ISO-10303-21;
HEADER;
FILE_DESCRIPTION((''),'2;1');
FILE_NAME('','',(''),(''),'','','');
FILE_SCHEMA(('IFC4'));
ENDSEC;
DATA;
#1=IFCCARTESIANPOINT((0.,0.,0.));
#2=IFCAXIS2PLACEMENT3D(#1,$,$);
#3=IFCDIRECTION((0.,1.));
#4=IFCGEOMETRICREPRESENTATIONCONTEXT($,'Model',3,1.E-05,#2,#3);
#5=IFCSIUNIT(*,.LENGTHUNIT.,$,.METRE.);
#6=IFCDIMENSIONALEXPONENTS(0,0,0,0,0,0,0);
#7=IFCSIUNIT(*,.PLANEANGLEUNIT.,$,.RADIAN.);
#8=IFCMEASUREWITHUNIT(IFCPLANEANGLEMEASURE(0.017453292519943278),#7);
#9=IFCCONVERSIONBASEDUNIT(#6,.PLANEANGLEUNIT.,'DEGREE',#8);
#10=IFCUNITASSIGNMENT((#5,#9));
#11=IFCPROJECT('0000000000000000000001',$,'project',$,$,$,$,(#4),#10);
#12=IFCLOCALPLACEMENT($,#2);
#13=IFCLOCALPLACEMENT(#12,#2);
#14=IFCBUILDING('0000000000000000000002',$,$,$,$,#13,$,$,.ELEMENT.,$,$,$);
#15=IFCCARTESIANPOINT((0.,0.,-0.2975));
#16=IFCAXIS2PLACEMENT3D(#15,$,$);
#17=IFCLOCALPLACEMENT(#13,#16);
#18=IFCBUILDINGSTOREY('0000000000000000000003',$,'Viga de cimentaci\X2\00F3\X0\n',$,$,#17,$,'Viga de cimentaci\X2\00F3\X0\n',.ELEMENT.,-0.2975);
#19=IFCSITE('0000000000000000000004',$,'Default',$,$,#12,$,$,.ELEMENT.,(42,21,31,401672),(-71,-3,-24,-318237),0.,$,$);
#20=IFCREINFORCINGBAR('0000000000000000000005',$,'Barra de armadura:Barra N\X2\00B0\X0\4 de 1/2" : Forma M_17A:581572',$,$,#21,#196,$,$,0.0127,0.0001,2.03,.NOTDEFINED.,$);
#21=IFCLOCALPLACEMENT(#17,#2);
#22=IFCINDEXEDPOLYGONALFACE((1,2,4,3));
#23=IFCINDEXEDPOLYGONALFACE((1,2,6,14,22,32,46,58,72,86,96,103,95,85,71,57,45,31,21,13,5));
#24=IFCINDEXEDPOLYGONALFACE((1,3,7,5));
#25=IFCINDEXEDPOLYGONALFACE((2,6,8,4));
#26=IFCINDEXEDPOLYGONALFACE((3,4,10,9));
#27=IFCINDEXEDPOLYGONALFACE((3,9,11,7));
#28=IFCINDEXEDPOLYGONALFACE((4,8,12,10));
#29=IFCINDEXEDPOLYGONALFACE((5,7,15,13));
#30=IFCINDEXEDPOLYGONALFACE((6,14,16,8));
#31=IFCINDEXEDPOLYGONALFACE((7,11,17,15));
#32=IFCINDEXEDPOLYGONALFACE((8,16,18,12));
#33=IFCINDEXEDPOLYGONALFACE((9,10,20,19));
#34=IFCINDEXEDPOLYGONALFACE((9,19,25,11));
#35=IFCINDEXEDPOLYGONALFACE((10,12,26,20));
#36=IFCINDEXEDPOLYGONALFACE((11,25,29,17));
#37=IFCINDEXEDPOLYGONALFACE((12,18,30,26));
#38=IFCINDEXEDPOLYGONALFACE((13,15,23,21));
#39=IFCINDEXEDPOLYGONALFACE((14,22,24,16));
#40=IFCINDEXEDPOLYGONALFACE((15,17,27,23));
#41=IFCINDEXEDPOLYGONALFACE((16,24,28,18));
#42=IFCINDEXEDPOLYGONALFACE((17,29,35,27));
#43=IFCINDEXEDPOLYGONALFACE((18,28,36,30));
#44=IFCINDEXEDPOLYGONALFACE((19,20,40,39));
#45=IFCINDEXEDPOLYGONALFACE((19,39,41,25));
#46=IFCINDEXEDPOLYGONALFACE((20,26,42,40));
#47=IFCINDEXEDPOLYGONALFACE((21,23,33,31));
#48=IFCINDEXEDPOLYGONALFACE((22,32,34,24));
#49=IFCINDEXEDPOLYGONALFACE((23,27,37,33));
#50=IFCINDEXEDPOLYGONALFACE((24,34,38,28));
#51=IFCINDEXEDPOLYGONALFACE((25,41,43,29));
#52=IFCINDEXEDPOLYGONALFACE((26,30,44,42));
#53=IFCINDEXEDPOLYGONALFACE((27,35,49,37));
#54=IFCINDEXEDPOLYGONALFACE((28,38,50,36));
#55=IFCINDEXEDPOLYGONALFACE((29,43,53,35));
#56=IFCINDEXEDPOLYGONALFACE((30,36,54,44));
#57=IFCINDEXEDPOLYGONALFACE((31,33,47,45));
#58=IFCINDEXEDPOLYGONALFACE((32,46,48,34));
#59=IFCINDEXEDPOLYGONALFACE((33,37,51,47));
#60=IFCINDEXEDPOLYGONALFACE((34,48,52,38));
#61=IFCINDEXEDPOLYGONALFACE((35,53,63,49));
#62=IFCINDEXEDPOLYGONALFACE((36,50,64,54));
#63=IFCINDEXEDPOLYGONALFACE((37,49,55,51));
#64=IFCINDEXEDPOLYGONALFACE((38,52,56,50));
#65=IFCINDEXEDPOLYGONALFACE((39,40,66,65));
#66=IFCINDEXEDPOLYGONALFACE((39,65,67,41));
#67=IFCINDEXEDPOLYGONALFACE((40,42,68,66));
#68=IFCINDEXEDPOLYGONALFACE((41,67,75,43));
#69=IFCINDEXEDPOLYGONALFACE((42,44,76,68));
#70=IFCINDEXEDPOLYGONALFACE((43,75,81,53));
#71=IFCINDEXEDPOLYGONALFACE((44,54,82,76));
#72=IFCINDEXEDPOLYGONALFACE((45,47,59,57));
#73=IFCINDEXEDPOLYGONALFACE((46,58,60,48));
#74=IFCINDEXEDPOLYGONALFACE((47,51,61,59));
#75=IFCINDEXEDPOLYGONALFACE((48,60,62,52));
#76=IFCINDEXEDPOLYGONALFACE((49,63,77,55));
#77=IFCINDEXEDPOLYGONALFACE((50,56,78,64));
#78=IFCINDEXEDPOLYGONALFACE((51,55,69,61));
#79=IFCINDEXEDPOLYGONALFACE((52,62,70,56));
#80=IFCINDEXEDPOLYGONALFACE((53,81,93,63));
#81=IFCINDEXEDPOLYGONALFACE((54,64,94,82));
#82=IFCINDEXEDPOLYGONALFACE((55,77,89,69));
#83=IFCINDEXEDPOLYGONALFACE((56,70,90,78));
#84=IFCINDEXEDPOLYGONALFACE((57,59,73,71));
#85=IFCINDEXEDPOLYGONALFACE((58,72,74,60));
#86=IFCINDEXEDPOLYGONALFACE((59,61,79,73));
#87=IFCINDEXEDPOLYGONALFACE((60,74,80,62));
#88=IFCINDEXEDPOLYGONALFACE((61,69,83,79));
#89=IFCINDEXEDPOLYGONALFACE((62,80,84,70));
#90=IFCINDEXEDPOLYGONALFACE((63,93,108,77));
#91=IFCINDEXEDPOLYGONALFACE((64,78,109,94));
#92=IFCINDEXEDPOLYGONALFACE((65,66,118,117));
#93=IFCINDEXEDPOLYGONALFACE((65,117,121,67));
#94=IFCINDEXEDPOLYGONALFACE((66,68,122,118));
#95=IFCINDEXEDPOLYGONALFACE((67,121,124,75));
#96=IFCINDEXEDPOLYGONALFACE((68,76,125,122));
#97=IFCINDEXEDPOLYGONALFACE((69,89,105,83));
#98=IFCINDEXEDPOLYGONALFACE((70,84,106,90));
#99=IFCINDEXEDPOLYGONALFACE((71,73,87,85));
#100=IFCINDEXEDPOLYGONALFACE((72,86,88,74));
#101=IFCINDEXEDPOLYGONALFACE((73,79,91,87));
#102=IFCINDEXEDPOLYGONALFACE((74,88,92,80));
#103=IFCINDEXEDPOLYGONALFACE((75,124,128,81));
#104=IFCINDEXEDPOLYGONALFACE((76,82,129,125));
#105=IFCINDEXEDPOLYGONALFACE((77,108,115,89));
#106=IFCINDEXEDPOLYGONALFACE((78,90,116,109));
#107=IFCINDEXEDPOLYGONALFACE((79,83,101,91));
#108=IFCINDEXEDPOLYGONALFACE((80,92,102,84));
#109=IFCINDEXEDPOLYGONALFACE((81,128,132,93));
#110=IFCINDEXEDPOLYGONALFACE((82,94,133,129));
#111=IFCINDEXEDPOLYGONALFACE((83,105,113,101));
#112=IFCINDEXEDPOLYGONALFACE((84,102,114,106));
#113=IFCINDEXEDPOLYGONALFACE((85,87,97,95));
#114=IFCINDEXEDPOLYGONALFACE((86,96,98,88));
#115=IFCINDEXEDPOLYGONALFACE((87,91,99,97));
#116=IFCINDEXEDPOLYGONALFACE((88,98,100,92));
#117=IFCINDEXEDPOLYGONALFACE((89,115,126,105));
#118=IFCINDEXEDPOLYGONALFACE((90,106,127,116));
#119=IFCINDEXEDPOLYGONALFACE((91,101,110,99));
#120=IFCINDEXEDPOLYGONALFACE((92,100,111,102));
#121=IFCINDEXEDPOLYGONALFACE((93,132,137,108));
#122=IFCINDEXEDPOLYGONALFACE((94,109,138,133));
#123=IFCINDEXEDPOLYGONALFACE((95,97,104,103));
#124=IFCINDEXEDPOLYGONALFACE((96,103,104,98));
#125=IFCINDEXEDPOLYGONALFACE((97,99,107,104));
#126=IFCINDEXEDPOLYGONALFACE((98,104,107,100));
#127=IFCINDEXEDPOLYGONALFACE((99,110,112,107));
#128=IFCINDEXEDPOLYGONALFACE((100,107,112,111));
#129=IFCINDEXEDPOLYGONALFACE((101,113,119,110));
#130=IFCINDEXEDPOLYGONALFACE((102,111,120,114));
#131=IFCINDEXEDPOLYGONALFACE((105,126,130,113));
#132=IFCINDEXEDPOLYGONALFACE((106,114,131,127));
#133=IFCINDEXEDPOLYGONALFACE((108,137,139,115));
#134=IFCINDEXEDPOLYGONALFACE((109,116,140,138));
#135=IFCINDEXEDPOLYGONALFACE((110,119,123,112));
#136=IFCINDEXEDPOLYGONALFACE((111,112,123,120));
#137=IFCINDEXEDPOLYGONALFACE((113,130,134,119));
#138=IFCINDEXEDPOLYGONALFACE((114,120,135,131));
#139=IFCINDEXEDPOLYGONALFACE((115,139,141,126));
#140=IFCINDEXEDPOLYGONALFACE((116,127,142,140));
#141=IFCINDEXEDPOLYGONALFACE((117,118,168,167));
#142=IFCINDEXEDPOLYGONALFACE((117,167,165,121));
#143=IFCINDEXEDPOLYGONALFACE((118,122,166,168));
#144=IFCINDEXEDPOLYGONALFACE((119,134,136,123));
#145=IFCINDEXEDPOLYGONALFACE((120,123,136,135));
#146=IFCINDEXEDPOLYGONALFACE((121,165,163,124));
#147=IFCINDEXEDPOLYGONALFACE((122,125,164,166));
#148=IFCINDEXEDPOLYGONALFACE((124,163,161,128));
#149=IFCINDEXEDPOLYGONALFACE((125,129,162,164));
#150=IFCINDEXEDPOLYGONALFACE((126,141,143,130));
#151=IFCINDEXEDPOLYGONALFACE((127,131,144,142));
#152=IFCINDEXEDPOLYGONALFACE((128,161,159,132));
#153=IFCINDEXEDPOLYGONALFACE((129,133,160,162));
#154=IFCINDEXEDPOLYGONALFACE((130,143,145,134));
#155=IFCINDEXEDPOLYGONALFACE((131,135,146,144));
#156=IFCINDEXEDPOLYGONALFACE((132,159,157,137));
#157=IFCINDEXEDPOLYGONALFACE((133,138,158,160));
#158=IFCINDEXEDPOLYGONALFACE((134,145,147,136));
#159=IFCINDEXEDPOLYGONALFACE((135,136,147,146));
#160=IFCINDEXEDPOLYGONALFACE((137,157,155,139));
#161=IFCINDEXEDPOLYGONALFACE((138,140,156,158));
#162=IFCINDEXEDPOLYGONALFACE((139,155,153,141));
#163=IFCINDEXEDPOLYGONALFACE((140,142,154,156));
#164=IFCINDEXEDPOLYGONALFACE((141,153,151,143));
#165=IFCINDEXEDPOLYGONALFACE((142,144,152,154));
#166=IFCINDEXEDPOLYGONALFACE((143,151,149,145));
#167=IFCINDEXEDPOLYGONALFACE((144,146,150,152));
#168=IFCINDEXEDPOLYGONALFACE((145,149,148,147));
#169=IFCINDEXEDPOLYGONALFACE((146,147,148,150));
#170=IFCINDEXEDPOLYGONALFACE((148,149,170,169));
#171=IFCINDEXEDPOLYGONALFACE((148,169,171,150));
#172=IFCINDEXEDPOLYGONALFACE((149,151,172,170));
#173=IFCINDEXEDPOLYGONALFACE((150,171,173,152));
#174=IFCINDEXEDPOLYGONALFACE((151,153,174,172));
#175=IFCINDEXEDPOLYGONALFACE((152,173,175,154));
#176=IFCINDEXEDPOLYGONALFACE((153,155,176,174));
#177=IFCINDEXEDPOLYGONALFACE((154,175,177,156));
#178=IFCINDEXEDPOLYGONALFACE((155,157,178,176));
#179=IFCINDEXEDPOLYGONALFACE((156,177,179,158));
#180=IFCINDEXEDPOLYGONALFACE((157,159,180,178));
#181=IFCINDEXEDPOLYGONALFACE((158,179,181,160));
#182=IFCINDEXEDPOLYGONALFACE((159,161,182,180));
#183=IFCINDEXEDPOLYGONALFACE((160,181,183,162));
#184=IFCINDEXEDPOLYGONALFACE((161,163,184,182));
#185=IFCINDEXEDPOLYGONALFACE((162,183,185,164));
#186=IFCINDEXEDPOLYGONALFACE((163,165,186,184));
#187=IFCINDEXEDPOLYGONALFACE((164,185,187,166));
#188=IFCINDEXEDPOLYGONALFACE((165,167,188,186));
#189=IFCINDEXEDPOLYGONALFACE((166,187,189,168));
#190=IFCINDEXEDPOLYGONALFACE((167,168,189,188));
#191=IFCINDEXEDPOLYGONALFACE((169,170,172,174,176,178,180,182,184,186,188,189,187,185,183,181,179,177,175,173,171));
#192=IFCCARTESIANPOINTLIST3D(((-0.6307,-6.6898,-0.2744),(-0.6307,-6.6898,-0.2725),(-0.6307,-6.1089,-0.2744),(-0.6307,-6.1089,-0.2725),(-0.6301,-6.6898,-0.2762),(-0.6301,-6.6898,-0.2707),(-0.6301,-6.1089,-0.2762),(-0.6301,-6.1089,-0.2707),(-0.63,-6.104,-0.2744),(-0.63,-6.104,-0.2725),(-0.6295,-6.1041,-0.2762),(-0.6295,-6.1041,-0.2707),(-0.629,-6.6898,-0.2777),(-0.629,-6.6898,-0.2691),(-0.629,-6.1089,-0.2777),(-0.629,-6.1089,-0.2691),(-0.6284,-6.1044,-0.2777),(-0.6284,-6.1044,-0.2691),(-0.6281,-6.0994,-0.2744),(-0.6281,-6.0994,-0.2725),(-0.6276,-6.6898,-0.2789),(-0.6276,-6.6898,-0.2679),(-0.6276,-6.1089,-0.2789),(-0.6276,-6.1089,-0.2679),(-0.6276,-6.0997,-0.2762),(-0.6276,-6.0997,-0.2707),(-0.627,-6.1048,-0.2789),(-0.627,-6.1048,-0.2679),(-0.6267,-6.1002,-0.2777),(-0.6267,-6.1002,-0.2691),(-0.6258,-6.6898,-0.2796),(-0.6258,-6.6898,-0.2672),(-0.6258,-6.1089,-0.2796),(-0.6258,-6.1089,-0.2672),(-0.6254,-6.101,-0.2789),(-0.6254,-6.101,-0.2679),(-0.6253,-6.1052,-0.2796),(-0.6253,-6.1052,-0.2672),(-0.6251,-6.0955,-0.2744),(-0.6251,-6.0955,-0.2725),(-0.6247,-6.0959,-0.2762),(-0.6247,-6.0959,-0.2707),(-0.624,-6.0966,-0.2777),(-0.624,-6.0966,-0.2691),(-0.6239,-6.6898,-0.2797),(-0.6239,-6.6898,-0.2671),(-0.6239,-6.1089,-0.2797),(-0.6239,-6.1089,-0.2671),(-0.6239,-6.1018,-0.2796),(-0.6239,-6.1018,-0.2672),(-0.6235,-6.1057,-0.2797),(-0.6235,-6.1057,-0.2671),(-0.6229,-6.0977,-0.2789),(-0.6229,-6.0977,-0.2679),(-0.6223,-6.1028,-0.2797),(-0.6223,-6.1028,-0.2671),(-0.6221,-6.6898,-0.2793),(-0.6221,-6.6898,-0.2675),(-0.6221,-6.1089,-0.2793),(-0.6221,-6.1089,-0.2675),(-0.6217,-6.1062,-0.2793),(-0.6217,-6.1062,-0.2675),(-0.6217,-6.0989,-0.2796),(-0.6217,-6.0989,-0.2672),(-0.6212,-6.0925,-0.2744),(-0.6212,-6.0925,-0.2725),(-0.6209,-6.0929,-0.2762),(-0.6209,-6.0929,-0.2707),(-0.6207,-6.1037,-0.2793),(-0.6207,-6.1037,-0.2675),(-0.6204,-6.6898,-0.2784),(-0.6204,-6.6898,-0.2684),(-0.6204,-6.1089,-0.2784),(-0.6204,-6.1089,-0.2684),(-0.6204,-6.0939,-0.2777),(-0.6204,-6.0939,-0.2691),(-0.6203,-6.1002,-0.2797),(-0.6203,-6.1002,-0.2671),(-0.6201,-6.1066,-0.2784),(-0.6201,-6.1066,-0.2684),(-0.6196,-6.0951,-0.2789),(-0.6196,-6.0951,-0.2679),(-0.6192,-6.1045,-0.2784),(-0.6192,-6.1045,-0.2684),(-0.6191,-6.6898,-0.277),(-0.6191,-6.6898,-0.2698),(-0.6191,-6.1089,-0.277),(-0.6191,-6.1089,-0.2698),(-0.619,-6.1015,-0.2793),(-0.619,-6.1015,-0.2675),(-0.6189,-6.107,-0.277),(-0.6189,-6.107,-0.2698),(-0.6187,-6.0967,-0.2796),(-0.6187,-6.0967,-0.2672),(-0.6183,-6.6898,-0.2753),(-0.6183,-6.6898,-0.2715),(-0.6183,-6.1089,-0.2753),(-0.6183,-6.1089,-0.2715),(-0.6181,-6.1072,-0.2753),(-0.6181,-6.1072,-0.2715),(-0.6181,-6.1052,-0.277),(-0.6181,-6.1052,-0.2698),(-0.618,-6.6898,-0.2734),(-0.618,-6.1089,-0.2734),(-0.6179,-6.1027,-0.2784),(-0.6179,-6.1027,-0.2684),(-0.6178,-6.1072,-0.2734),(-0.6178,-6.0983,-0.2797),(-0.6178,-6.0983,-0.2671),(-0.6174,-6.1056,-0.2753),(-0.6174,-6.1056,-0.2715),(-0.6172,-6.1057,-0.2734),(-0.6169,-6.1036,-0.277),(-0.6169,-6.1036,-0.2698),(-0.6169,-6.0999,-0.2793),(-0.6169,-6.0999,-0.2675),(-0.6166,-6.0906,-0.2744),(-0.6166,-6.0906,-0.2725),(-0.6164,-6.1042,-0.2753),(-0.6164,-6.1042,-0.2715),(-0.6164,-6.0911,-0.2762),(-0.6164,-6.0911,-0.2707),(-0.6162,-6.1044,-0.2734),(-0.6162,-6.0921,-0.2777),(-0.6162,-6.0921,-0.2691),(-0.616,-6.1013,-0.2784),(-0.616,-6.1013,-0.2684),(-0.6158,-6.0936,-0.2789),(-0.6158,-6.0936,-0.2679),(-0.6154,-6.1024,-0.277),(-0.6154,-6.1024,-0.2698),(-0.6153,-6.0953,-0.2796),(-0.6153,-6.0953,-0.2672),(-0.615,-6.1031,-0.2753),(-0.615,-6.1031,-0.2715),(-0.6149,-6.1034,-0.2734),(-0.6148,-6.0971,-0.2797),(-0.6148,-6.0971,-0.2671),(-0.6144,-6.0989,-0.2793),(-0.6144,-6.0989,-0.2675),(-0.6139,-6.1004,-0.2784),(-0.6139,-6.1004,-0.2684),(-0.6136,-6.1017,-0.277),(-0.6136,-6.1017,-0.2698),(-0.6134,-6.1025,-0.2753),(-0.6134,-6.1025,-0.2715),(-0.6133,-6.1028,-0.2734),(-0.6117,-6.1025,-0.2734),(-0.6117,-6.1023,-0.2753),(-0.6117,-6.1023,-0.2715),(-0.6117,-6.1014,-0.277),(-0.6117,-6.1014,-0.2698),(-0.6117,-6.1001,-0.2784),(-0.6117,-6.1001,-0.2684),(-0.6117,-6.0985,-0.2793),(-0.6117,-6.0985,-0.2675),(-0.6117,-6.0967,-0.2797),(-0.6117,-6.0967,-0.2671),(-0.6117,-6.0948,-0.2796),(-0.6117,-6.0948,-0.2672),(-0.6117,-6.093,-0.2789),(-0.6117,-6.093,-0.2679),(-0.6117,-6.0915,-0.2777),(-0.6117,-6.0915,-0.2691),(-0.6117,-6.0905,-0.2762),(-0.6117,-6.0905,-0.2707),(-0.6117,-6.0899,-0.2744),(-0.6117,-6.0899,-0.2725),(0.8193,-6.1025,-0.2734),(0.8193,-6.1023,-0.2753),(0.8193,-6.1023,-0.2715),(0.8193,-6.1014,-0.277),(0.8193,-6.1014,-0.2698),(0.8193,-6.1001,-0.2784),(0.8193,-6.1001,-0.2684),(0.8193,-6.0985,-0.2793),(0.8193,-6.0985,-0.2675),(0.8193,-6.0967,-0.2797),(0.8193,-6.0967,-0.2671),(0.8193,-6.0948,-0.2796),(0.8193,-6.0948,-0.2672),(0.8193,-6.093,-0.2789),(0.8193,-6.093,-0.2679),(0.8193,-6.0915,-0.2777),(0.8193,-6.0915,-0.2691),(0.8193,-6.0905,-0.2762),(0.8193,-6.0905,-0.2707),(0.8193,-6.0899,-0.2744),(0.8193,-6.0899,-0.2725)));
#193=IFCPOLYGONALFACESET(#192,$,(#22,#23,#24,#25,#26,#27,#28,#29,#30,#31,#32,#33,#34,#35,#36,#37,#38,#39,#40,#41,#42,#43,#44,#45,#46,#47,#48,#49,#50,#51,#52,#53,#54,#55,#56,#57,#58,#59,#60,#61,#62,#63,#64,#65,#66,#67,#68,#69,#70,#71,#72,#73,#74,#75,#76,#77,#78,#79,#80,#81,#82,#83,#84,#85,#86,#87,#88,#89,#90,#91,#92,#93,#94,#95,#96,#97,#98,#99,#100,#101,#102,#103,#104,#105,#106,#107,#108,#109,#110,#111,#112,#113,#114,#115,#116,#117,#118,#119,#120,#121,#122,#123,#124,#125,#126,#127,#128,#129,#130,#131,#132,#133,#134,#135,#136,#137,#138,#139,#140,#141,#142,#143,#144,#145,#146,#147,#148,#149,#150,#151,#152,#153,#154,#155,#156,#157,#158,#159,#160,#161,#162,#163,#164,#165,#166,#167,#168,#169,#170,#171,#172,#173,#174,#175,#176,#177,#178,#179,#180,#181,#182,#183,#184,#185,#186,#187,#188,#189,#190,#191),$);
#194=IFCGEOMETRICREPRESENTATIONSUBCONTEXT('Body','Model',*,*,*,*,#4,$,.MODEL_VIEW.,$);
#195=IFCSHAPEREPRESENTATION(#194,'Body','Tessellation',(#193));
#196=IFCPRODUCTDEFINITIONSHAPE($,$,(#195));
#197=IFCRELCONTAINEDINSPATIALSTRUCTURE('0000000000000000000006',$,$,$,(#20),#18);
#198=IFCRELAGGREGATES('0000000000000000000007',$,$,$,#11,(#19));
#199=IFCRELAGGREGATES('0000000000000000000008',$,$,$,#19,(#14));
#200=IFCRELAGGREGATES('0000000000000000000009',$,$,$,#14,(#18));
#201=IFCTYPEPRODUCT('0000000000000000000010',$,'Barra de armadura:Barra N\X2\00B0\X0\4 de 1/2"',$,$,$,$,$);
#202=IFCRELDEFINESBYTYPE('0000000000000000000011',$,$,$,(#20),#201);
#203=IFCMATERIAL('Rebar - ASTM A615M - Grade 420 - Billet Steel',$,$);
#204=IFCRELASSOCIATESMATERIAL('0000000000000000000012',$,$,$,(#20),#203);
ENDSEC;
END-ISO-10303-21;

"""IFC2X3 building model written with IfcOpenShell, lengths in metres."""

from ifc_helpers import new_model, entity, si_unit, converted_unit, direction, frame, origin, place, context, subcontext, project, spatial, material, type_object, element, save


model = new_model("IFC2X3")

# Units and contexts
model_context = context("Model", 3, precision=1e-05, world=origin(), true_north=direction((0.0, 1.0)))
body_context = subcontext(model_context, "Body", "Model", "MODEL_VIEW")
ifc_project = project(units=[si_unit("LENGTHUNIT", "METRE"), converted_unit("PLANEANGLEUNIT", "DEGREE", entity("IfcPlaneAngleMeasure", 0.017453292519943278), si_unit("PLANEANGLEUNIT", "RADIAN"), dimensions=[0, 0, 0, 0, 0, 0, 0])], contexts=[model_context])

# Site, building, storey
site_placement = place(None, origin())
site = spatial("IfcSite", under=ifc_project, at=site_placement, Name="Default", CompositionType="ELEMENT", RefLatitude=(42, 21, 31, 401672), RefLongitude=(-71, -3, -24, -318237), RefElevation=0.0)
building_placement = place(site_placement, origin())
building = spatial("IfcBuilding", under=site, at=building_placement, CompositionType="ELEMENT")
storey_placement = place(building_placement, frame((0.0, 0.0, -0.2975)))
storey = spatial("IfcBuildingStorey", under=building, at=storey_placement, Name="Viga de cimentación", LongName="Viga de cimentación", CompositionType="ELEMENT", Elevation=-0.2975)

# Reinforcing bar
ifc_material = material(Name="Rebar - ASTM A615M - Grade 420 - Billet Steel")
type_product_1 = type_object("IfcTypeProduct", Name="Barra de armadura:Barra N°4 de 1/2\"")
reinforcing_bar_1_placement = place(storey_placement, origin())
element("IfcReinforcingBar", 1, at=reinforcing_bar_1_placement, inside=storey, type_object=type_product_1, material=ifc_material, Name="Barra de armadura:Barra N°4 de 1/2\" : Forma M_17A:581572", BarLength=2.03, BarRole="NOTDEFINED", CrossSectionArea=0.0001, NominalDiameter=0.0127, context=body_context, shape_type="AdvancedSweptSolid", body=[
    entity("IfcSweptDiskSolid", entity("IfcCompositeCurve", [entity("IfcCompositeCurveSegment", "CONTINUOUS", True, entity("IfcPolyline", [entity("IfcCartesianPoint", [-0.6244, -6.6898, -0.2734]), entity("IfcCartesianPoint", [-0.6244, -6.1089, -0.2734])])), entity("IfcCompositeCurveSegment", "CONTINUOUS", True, entity("IfcTrimmedCurve", entity("IfcCircle", entity("IfcAxis2Placement3D", entity("IfcCartesianPoint", [-0.6117, -6.1089, -0.2734]), entity("IfcDirection", [0.0, 0.0, -1.0]), entity("IfcDirection", [0.0, 1.0, 0.0])), 0.0127), [entity("IfcParameterValue", 270.0)], [entity("IfcParameterValue", 360.0)], True, "PARAMETER")), entity("IfcCompositeCurveSegment", "CONTINUOUS", True, entity("IfcPolyline", [entity("IfcCartesianPoint", [-0.6117, -6.0962, -0.2734]), entity("IfcCartesianPoint", [0.8193, -6.0962, -0.2734])]))], False), 0.0063, None, 0.0, 92.0),
])

save(model, "model.ifc")
